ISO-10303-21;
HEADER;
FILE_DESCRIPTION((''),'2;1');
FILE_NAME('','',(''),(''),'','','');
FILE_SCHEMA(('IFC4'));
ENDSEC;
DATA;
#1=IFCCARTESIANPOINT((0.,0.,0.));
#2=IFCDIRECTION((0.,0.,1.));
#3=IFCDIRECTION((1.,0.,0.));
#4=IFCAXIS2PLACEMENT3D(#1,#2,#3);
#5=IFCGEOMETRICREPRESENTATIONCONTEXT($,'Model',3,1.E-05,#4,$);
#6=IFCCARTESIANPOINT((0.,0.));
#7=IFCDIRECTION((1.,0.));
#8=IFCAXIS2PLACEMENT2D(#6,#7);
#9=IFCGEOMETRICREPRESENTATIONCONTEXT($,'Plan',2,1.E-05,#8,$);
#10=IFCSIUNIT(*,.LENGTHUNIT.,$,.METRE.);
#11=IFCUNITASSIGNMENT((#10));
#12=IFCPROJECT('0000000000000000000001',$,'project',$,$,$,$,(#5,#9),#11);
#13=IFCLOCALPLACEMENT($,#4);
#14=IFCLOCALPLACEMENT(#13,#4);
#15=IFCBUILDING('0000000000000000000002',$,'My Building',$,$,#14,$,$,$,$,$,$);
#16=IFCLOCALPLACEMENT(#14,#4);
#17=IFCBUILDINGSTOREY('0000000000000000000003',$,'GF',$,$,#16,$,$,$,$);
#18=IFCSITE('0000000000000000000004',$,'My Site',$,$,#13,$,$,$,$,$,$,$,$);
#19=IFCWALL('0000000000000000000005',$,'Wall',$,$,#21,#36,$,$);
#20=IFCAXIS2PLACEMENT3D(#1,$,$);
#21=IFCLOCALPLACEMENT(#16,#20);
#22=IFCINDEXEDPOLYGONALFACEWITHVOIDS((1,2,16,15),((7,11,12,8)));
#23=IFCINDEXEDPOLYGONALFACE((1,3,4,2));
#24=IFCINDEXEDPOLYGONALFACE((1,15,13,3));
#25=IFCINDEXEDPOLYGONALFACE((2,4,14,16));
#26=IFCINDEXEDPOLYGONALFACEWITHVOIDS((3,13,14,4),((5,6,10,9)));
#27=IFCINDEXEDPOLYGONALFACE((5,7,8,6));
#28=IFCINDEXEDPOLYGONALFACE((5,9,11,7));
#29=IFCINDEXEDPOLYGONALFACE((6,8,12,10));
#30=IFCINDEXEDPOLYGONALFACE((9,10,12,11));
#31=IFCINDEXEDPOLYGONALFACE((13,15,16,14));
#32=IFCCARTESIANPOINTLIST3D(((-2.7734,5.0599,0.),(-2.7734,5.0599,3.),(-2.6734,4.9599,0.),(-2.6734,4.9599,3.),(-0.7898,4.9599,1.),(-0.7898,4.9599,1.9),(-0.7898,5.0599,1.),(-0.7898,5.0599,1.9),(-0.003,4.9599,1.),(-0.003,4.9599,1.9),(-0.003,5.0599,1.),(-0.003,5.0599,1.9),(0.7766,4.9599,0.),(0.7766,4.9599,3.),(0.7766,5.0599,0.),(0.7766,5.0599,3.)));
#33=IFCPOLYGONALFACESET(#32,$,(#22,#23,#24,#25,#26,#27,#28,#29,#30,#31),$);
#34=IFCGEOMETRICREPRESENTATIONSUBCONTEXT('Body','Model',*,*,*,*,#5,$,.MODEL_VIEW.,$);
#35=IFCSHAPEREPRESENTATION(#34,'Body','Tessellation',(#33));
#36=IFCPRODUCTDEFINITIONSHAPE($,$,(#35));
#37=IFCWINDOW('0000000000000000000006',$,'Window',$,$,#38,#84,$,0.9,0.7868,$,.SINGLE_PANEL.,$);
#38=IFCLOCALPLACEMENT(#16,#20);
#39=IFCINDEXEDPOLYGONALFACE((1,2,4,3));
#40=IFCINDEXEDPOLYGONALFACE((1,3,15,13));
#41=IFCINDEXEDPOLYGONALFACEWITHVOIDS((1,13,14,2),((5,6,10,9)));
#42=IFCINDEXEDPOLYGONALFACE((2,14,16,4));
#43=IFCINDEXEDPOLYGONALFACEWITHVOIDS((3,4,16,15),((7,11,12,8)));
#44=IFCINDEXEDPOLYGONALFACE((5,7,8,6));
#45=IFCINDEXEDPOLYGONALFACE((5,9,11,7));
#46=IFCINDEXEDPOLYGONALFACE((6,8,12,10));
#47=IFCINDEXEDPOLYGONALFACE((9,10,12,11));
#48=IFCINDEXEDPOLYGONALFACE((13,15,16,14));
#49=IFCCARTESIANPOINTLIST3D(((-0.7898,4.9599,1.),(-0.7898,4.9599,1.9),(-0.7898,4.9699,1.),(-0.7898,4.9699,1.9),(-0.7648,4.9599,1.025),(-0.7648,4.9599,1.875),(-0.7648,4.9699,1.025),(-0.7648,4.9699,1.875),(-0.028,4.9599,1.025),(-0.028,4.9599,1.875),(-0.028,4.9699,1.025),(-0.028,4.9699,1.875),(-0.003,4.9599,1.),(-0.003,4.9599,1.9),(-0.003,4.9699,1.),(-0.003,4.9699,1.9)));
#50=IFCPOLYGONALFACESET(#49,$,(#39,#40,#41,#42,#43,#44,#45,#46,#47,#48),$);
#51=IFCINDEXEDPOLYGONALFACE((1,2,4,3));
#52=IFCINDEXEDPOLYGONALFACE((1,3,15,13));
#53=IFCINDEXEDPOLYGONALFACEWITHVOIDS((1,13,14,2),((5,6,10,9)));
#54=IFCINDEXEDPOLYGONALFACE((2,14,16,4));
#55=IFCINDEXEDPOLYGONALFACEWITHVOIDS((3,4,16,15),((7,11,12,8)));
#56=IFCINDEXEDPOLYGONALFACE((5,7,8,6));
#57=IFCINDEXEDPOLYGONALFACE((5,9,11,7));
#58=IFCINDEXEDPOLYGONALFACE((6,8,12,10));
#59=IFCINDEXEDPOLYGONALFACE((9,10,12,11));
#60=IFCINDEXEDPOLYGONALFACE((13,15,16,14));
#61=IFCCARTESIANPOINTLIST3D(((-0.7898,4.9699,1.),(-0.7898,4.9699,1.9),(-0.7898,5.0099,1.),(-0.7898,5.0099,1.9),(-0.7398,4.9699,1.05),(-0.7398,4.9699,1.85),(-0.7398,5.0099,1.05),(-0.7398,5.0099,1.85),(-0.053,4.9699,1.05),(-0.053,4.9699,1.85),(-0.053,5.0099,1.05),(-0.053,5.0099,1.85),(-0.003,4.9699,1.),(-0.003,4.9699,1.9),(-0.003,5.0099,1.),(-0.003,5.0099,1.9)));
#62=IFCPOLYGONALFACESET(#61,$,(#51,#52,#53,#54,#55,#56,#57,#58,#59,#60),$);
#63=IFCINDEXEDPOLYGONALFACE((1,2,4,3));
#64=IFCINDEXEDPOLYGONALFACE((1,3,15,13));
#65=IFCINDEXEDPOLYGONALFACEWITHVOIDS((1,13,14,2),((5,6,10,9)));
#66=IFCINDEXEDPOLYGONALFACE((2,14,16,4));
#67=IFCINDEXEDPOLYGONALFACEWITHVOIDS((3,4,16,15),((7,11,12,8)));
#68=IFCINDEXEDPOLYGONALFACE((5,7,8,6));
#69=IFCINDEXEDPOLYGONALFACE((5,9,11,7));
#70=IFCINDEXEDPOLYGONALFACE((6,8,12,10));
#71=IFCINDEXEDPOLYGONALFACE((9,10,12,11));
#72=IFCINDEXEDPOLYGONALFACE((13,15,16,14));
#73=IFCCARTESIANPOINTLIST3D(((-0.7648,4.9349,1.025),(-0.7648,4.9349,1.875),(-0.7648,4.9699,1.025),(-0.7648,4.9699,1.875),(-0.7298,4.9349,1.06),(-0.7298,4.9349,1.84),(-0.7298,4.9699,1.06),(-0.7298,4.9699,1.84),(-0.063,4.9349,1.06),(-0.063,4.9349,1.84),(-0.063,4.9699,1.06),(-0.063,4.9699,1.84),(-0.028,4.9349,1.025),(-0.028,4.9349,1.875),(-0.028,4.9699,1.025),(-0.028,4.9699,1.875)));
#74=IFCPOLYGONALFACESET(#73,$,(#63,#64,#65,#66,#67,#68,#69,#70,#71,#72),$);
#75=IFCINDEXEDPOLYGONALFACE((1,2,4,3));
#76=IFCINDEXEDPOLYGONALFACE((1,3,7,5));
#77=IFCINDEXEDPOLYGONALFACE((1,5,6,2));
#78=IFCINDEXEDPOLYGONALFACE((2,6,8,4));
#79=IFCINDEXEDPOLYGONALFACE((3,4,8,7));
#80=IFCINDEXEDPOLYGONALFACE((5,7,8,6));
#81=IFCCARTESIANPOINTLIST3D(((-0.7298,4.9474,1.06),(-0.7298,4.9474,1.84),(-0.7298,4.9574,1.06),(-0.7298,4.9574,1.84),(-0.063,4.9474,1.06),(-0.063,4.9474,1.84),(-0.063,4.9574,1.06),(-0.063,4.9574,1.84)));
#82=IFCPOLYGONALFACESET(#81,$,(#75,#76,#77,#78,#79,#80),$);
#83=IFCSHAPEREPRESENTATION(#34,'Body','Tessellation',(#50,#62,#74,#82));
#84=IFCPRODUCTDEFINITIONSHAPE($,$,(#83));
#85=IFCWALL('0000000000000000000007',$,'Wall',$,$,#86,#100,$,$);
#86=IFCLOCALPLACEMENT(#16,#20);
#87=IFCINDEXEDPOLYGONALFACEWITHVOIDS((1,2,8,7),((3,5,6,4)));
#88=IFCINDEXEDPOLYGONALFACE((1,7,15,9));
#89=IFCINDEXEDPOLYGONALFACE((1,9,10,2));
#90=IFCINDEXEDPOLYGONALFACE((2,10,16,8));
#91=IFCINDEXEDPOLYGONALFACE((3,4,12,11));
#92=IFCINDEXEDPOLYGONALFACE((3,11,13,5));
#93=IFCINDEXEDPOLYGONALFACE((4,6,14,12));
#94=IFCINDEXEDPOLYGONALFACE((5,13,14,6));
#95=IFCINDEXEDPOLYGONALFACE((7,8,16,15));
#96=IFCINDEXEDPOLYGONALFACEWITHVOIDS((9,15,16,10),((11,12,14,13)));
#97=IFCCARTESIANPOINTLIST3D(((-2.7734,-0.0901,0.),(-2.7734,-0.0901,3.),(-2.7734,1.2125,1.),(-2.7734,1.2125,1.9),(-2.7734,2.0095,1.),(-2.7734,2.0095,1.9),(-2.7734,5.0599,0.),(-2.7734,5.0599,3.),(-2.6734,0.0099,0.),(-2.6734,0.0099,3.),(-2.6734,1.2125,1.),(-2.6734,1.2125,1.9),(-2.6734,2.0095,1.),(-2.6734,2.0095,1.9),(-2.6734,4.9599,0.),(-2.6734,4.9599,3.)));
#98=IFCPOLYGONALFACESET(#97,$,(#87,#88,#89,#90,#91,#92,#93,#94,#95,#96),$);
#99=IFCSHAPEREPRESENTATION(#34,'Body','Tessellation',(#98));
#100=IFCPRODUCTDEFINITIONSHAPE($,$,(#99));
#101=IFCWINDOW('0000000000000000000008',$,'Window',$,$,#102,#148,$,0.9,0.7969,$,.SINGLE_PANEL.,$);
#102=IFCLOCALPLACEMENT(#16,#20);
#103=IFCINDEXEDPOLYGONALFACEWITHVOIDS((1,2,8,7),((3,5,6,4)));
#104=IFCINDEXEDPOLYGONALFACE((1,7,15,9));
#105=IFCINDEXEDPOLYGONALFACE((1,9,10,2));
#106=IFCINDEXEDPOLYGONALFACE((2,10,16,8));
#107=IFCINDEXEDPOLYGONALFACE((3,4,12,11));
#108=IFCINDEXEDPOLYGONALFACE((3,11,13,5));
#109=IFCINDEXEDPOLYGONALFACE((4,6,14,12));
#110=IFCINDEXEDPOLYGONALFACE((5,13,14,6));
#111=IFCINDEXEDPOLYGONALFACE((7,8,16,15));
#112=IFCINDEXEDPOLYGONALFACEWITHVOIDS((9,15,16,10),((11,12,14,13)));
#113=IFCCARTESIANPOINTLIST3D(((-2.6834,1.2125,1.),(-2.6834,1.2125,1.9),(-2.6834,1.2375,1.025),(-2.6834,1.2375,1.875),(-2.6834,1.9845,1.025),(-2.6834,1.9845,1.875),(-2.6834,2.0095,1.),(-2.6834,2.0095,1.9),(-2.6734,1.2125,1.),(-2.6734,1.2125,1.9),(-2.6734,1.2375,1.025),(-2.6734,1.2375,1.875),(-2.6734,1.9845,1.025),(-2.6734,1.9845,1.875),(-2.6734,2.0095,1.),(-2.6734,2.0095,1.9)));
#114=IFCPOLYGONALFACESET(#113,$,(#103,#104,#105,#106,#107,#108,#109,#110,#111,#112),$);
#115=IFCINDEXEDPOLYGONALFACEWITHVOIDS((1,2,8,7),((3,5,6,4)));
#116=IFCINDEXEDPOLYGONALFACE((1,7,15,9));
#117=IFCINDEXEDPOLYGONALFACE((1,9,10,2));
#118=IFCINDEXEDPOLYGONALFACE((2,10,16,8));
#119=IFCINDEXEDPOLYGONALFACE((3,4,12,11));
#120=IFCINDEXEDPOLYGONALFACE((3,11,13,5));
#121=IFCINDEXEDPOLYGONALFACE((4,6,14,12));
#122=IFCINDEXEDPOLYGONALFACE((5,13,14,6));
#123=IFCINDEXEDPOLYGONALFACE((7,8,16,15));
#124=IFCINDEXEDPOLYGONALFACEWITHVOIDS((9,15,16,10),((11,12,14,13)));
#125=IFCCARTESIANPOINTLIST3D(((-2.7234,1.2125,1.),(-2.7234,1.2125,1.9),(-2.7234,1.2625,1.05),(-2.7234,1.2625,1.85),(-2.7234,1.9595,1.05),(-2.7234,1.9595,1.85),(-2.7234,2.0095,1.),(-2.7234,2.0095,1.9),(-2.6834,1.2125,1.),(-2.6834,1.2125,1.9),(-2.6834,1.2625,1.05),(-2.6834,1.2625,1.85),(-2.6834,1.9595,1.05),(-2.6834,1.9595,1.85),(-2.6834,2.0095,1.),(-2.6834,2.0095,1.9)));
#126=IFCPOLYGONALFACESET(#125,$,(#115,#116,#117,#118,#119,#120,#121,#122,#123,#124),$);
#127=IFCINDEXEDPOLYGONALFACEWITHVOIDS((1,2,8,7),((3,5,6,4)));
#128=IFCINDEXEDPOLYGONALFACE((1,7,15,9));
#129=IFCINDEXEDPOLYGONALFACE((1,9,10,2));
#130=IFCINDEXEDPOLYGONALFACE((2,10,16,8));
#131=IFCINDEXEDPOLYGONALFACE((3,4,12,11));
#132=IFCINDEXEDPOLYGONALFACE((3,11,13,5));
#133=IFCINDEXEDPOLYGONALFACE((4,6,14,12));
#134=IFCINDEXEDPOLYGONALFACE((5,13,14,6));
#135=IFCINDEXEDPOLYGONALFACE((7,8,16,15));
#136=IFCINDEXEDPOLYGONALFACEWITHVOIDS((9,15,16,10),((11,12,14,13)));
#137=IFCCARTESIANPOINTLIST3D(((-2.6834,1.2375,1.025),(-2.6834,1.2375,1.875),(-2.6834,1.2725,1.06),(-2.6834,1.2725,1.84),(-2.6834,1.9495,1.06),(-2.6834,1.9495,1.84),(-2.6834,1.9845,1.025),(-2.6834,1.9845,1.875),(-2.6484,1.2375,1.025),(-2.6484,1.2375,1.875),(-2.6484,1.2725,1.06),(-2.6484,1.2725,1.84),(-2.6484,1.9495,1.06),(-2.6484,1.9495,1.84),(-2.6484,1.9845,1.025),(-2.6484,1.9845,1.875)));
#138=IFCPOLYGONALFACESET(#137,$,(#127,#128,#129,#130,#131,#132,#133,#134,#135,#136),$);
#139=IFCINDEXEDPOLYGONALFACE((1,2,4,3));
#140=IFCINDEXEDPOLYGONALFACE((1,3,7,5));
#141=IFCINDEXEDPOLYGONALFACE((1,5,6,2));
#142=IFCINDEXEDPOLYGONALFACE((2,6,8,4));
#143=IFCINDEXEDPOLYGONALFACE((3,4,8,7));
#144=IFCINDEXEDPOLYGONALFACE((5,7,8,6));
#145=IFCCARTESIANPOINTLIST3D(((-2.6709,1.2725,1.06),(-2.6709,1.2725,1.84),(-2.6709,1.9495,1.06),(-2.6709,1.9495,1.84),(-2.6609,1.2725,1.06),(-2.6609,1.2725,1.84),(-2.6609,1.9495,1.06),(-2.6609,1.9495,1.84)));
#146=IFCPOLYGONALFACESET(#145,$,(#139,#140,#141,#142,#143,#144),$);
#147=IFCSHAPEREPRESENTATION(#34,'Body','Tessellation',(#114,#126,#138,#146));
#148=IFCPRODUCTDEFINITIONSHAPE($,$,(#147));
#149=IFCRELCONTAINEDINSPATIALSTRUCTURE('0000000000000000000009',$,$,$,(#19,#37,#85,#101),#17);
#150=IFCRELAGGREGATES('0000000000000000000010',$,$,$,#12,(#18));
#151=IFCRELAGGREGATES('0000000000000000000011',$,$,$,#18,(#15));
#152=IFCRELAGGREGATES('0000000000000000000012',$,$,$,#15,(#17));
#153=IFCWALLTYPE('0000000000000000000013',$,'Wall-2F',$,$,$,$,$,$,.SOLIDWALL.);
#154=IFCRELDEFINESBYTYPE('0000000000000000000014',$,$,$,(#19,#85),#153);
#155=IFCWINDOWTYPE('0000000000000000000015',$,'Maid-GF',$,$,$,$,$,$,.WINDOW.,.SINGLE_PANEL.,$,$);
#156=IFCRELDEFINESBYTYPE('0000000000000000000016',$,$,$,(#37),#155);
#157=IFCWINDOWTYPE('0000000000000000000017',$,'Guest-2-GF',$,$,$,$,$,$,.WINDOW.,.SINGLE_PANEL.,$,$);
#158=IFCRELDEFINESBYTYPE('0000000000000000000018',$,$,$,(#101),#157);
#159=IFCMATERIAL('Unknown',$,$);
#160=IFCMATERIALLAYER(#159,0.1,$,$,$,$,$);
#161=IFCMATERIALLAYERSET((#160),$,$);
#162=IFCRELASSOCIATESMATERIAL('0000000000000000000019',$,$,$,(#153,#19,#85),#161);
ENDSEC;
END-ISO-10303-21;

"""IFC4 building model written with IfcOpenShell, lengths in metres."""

from ifc_helpers import new_model, entity, si_unit, frame, origin_with_axes, origin_2d_with_axis, place, context, subcontext, project, spatial, line, indexed_curve, outline, extrude, shape, source, transform, mapped, material, layer, layer_set, layer_usage, type_object, type_shapes, element, fill, save


model = new_model("IFC4")

# Units and contexts
model_context = context("Model", 3, precision=1e-05, world=origin_with_axes())
plan_context = context("Plan", 2, precision=1e-05, world=origin_2d_with_axis())
body_context_1 = subcontext(model_context, "Body", "Model", "MODEL_VIEW")
body_context_2 = subcontext(plan_context, "Body", "Plan", "PLAN_VIEW")
ifc_project = project(units=[si_unit("LENGTHUNIT", "METRE")], contexts=[model_context, plan_context])

# Site, building, storey
site_placement = place(None, origin_with_axes())
site = spatial("IfcSite", under=ifc_project, at=site_placement, Name="My Site")
building_placement = place(site_placement, origin_with_axes())
building = spatial("IfcBuilding", under=site, at=building_placement, Name="My Building")
storey_placement = place(building_placement, origin_with_axes())
storey = spatial("IfcBuildingStorey", under=building, at=storey_placement, Name="GF")

# Shared definitions
ifc_material_1 = material(Name="Unknown")

# Shared definitions
ifc_layer_1 = layer(ifc_material_1, 0.1)
ifc_layer_set_1 = layer_set([ifc_layer_1])
wall_type = type_object("IfcWallType", Name="Wall-2F", PredefinedType="SOLIDWALL", material=ifc_layer_set_1)

# Walls, openings, windows
ifc_layer_usage_1 = layer_usage(ifc_layer_set_1, "AXIS2", "POSITIVE", 0.0)
wall_1_placement = place(storey_placement, frame((0.7766, 5.0599, 0.0), z_axis=(0.0, 0.0, 1.0), x_axis=(-1.0, 0.0, 0.0)))
wall_1 = element("IfcWall", 1, at=wall_1_placement, inside=storey, type_object=wall_type, material=ifc_layer_usage_1, Name="Wall", context=body_context_1, shape_type="SweptSolid", body=[
    extrude(outline(indexed_curve([(0.0, 0.0), (0.0, 0.1), (3.45, 0.1), (3.55, 0.0)], segments=[line(1, 2, 3, 4, 1)])), origin_with_axes(), (0.0, 0.0, 1.0), 3.0),
])
shared_shape_1 = source(origin_with_axes(), body_context_1, "Body", "SweptSolid", [
    extrude(outline(indexed_curve([(0.0, 0.0), (0.7868, 0.0), (0.7868, 0.9), (0.0, 0.9)], segments=[line(1, 2, 3, 4, 1)])), frame((0.0, -0.6, 0.0), z_axis=(0.0, -1.0, 0.0), x_axis=(1.0, 0.0, 0.0)), (0.0, 0.0, -1.0), 1.2),
])
opening_1_placement = place(wall_1_placement, frame((0.7796, 0.0, 1.0), z_axis=(0.0, 0.0, 1.0), x_axis=(1.0, 0.0, 0.0)))
opening_1 = element("IfcOpeningElement", 2, at=opening_1_placement, cuts=wall_1, PredefinedType="OPENING", context=body_context_1, shape_type="MappedRepresentation", body=[
    mapped(shared_shape_1, transform((0.0, 0.0, 0.0), x_axis=(1.0, 0.0, 0.0), y_axis=(0.0, 1.0, 0.0), z_axis=(0.0, 0.0, 1.0), scale=1.0)),
])
window_type_1 = type_object("IfcWindowType", Name="Maid-GF", PartitioningType="SINGLE_PANEL", PredefinedType="WINDOW")
shared_shape_2 = source(origin_with_axes(), body_context_1, "Body", "SweptSolid", [
    extrude(outline(indexed_curve([(0.0, 0.0), (0.7868, 0.0), (0.7868, 0.9), (0.0, 0.9)], segments=[line(1, 2, 3, 4, 1)]), holes=[indexed_curve([(0.025, 0.025), (0.7618, 0.025), (0.7618, 0.875), (0.025, 0.875)], segments=[line(1, 2, 3, 4, 1)])]), frame((0.0, 0.09, 0.0), z_axis=(0.0, -1.0, 0.0), x_axis=(1.0, 0.0, 0.0)), (0.0, 0.0, -1.0), 0.01),
    extrude(outline(indexed_curve([(0.0, 0.0), (0.7868, 0.0), (0.7868, 0.9), (0.0, 0.9)], segments=[line(1, 2, 3, 4, 1)]), holes=[indexed_curve([(0.05, 0.05), (0.7368, 0.05), (0.7368, 0.85), (0.05, 0.85)], segments=[line(1, 2, 3, 4, 1)])]), frame((0.0, 0.05, 0.0), z_axis=(0.0, -1.0, 0.0), x_axis=(1.0, 0.0, 0.0)), (0.0, 0.0, -1.0), 0.04),
    extrude(outline(indexed_curve([(0.0, 0.0), (0.7368, 0.0), (0.7368, 0.85), (0.0, 0.85)], segments=[line(1, 2, 3, 4, 1)]), holes=[indexed_curve([(0.035, 0.035), (0.7018, 0.035), (0.7018, 0.815), (0.035, 0.815)], segments=[line(1, 2, 3, 4, 1)])]), frame((0.025, 0.09, 0.025), z_axis=(0.0, -1.0, 0.0), x_axis=(1.0, 0.0, 0.0)), (0.0, 0.0, -1.0), 0.035),
    extrude(outline(indexed_curve([(0.035, 0.035), (0.7018, 0.035), (0.7018, 0.815), (0.035, 0.815)], segments=[line(1, 2, 3, 4, 1)])), frame((0.025, 0.1025, 0.025), z_axis=(0.0, -1.0, 0.0), x_axis=(1.0, 0.0, 0.0)), (0.0, 0.0, -1.0), 0.01),
])
shared_shape_3 = source(origin_with_axes(), body_context_2, "Body", "Curve2D", [
    entity("IfcIndexedPolyCurve", entity("IfcCartesianPointList2D", [[0.05, 0.05], [0.7368, 0.05]])),
    entity("IfcIndexedPolyCurve", entity("IfcCartesianPointList2D", [[0.0, 0.1], [0.025, 0.1], [0.025, 0.09], [0.05, 0.09], [0.05, 0.05], [0.0, 0.05]]), [entity("IfcLineIndex", [1, 2, 3, 4, 5, 6, 1])]),
    entity("IfcIndexedPolyCurve", entity("IfcCartesianPointList2D", [[0.7868, 0.1], [0.7618, 0.1], [0.7618, 0.09], [0.7368, 0.09], [0.7368, 0.05], [0.7868, 0.05]]), [entity("IfcLineIndex", [1, 2, 3, 4, 5, 6, 1])]),
    entity("IfcIndexedPolyCurve", entity("IfcCartesianPointList2D", [[0.025, 0.09], [0.06, 0.09], [0.06, 0.125], [0.025, 0.125]]), [entity("IfcLineIndex", [1, 2, 3, 4, 1])]),
    entity("IfcIndexedPolyCurve", entity("IfcCartesianPointList2D", [[0.7618, 0.09], [0.7268, 0.09], [0.7268, 0.125], [0.7618, 0.125]]), [entity("IfcLineIndex", [1, 2, 3, 4, 1])]),
    entity("IfcIndexedPolyCurve", entity("IfcCartesianPointList2D", [[0.06, 0.09], [0.7268, 0.09]])),
    entity("IfcIndexedPolyCurve", entity("IfcCartesianPointList2D", [[0.06, 0.125], [0.7268, 0.125]])),
    entity("IfcIndexedPolyCurve", entity("IfcCartesianPointList2D", [[0.06, 0.1075], [0.7268, 0.1075]])),
])
type_shapes(window_type_1, [shared_shape_2, shared_shape_3])
window_1_placement = place(opening_1_placement, frame((0.0, 0.0, 0.0), z_axis=(0.0, 0.0, 1.0), x_axis=(1.0, 0.0, 0.0)))
window_1 = element("IfcWindow", 3, at=window_1_placement, inside=storey, type_object=window_type_1, Name="Window", OverallHeight=0.9, OverallWidth=0.7868, PartitioningType="SINGLE_PANEL", shapes=[
    shape(body_context_1, "Body", "MappedRepresentation", [mapped(shared_shape_2, transform((0.0, 0.0, 0.0), x_axis=(1.0, 0.0, 0.0), y_axis=(0.0, 1.0, 0.0), z_axis=(0.0, 0.0, 1.0), scale=1.0))]),
    shape(body_context_2, "Body", "MappedRepresentation", [mapped(shared_shape_3, transform((0.0, 0.0, 0.0), x_axis=(1.0, 0.0, 0.0), y_axis=(0.0, 1.0, 0.0), z_axis=(0.0, 0.0, 1.0), scale=1.0))]),
])
fill(opening_1, window_1)
ifc_layer_usage_2 = layer_usage(ifc_layer_set_1, "AXIS2", "POSITIVE", 0.0)
wall_2_placement = place(storey_placement, frame((-2.7734, 5.0599, 0.0), z_axis=(0.0, 0.0, 1.0), x_axis=(0.0, -1.0, 0.0)))
wall_2 = element("IfcWall", 4, at=wall_2_placement, inside=storey, type_object=wall_type, material=ifc_layer_usage_2, Name="Wall", context=body_context_1, shape_type="SweptSolid", body=[
    extrude(outline(indexed_curve([(0.0, 0.0), (0.1, 0.1), (5.05, 0.1), (5.15, 0.0)], segments=[line(1, 2, 3, 4, 1)])), origin_with_axes(), (0.0, 0.0, 1.0), 3.0),
])
shared_shape_4 = source(origin_with_axes(), body_context_1, "Body", "SweptSolid", [
    extrude(outline(indexed_curve([(0.0, 0.0), (0.7969, 0.0), (0.7969, 0.9), (0.0, 0.9)], segments=[line(1, 2, 3, 4, 1)])), frame((0.0, -0.6, 0.0), z_axis=(0.0, -1.0, 0.0), x_axis=(1.0, 0.0, 0.0)), (0.0, 0.0, -1.0), 1.2),
])
opening_2_placement = place(wall_2_placement, frame((3.0504, 0.0, 1.0), z_axis=(0.0, 0.0, 1.0), x_axis=(1.0, 0.0, 0.0)))
opening_2 = element("IfcOpeningElement", 5, at=opening_2_placement, cuts=wall_2, PredefinedType="OPENING", context=body_context_1, shape_type="MappedRepresentation", body=[
    mapped(shared_shape_4, transform((0.0, 0.0, 0.0), x_axis=(1.0, 0.0, 0.0), y_axis=(0.0, 1.0, 0.0), z_axis=(0.0, 0.0, 1.0), scale=1.0)),
])
window_type_2 = type_object("IfcWindowType", Name="Guest-2-GF", PartitioningType="SINGLE_PANEL", PredefinedType="WINDOW")
shared_shape_5 = source(origin_with_axes(), body_context_1, "Body", "SweptSolid", [
    extrude(outline(indexed_curve([(0.0, 0.0), (0.7969, 0.0), (0.7969, 0.9), (0.0, 0.9)], segments=[line(1, 2, 3, 4, 1)]), holes=[indexed_curve([(0.025, 0.025), (0.7719, 0.025), (0.7719, 0.875), (0.025, 0.875)], segments=[line(1, 2, 3, 4, 1)])]), frame((0.0, 0.09, 0.0), z_axis=(0.0, -1.0, 0.0), x_axis=(1.0, 0.0, 0.0)), (0.0, 0.0, -1.0), 0.01),
    extrude(outline(indexed_curve([(0.0, 0.0), (0.7969, 0.0), (0.7969, 0.9), (0.0, 0.9)], segments=[line(1, 2, 3, 4, 1)]), holes=[indexed_curve([(0.05, 0.05), (0.7469, 0.05), (0.7469, 0.85), (0.05, 0.85)], segments=[line(1, 2, 3, 4, 1)])]), frame((0.0, 0.05, 0.0), z_axis=(0.0, -1.0, 0.0), x_axis=(1.0, 0.0, 0.0)), (0.0, 0.0, -1.0), 0.04),
    extrude(outline(indexed_curve([(0.0, 0.0), (0.7469, 0.0), (0.7469, 0.85), (0.0, 0.85)], segments=[line(1, 2, 3, 4, 1)]), holes=[indexed_curve([(0.035, 0.035), (0.7119, 0.035), (0.7119, 0.815), (0.035, 0.815)], segments=[line(1, 2, 3, 4, 1)])]), frame((0.025, 0.09, 0.025), z_axis=(0.0, -1.0, 0.0), x_axis=(1.0, 0.0, 0.0)), (0.0, 0.0, -1.0), 0.035),
    extrude(outline(indexed_curve([(0.035, 0.035), (0.7119, 0.035), (0.7119, 0.815), (0.035, 0.815)], segments=[line(1, 2, 3, 4, 1)])), frame((0.025, 0.1025, 0.025), z_axis=(0.0, -1.0, 0.0), x_axis=(1.0, 0.0, 0.0)), (0.0, 0.0, -1.0), 0.01),
])
shared_shape_6 = source(origin_with_axes(), body_context_2, "Body", "Curve2D", [
    entity("IfcIndexedPolyCurve", entity("IfcCartesianPointList2D", [[0.05, 0.05], [0.7469, 0.05]])),
    entity("IfcIndexedPolyCurve", entity("IfcCartesianPointList2D", [[0.0, 0.1], [0.025, 0.1], [0.025, 0.09], [0.05, 0.09], [0.05, 0.05], [0.0, 0.05]]), [entity("IfcLineIndex", [1, 2, 3, 4, 5, 6, 1])]),
    entity("IfcIndexedPolyCurve", entity("IfcCartesianPointList2D", [[0.7969, 0.1], [0.7719, 0.1], [0.7719, 0.09], [0.7469, 0.09], [0.7469, 0.05], [0.7969, 0.05]]), [entity("IfcLineIndex", [1, 2, 3, 4, 5, 6, 1])]),
    entity("IfcIndexedPolyCurve", entity("IfcCartesianPointList2D", [[0.025, 0.09], [0.06, 0.09], [0.06, 0.125], [0.025, 0.125]]), [entity("IfcLineIndex", [1, 2, 3, 4, 1])]),
    entity("IfcIndexedPolyCurve", entity("IfcCartesianPointList2D", [[0.7719, 0.09], [0.7369, 0.09], [0.7369, 0.125], [0.7719, 0.125]]), [entity("IfcLineIndex", [1, 2, 3, 4, 1])]),
    entity("IfcIndexedPolyCurve", entity("IfcCartesianPointList2D", [[0.06, 0.09], [0.7369, 0.09]])),
    entity("IfcIndexedPolyCurve", entity("IfcCartesianPointList2D", [[0.06, 0.125], [0.7369, 0.125]])),
    entity("IfcIndexedPolyCurve", entity("IfcCartesianPointList2D", [[0.06, 0.1075], [0.7369, 0.1075]])),
])
type_shapes(window_type_2, [shared_shape_5, shared_shape_6])
window_2_placement = place(opening_2_placement, frame((0.0, 0.0, 0.0), z_axis=(0.0, 0.0, 1.0), x_axis=(1.0, 0.0, 0.0)))
window_2 = element("IfcWindow", 6, at=window_2_placement, inside=storey, type_object=window_type_2, Name="Window", OverallHeight=0.9, OverallWidth=0.7969, PartitioningType="SINGLE_PANEL", shapes=[
    shape(body_context_1, "Body", "MappedRepresentation", [mapped(shared_shape_5, transform((0.0, 0.0, 0.0), x_axis=(1.0, 0.0, 0.0), y_axis=(0.0, 1.0, 0.0), z_axis=(0.0, 0.0, 1.0), scale=1.0))]),
    shape(body_context_2, "Body", "MappedRepresentation", [mapped(shared_shape_6, transform((0.0, 0.0, 0.0), x_axis=(1.0, 0.0, 0.0), y_axis=(0.0, 1.0, 0.0), z_axis=(0.0, 0.0, 1.0), scale=1.0))]),
])
fill(opening_2, window_2)

save(model, "model.ifc")
